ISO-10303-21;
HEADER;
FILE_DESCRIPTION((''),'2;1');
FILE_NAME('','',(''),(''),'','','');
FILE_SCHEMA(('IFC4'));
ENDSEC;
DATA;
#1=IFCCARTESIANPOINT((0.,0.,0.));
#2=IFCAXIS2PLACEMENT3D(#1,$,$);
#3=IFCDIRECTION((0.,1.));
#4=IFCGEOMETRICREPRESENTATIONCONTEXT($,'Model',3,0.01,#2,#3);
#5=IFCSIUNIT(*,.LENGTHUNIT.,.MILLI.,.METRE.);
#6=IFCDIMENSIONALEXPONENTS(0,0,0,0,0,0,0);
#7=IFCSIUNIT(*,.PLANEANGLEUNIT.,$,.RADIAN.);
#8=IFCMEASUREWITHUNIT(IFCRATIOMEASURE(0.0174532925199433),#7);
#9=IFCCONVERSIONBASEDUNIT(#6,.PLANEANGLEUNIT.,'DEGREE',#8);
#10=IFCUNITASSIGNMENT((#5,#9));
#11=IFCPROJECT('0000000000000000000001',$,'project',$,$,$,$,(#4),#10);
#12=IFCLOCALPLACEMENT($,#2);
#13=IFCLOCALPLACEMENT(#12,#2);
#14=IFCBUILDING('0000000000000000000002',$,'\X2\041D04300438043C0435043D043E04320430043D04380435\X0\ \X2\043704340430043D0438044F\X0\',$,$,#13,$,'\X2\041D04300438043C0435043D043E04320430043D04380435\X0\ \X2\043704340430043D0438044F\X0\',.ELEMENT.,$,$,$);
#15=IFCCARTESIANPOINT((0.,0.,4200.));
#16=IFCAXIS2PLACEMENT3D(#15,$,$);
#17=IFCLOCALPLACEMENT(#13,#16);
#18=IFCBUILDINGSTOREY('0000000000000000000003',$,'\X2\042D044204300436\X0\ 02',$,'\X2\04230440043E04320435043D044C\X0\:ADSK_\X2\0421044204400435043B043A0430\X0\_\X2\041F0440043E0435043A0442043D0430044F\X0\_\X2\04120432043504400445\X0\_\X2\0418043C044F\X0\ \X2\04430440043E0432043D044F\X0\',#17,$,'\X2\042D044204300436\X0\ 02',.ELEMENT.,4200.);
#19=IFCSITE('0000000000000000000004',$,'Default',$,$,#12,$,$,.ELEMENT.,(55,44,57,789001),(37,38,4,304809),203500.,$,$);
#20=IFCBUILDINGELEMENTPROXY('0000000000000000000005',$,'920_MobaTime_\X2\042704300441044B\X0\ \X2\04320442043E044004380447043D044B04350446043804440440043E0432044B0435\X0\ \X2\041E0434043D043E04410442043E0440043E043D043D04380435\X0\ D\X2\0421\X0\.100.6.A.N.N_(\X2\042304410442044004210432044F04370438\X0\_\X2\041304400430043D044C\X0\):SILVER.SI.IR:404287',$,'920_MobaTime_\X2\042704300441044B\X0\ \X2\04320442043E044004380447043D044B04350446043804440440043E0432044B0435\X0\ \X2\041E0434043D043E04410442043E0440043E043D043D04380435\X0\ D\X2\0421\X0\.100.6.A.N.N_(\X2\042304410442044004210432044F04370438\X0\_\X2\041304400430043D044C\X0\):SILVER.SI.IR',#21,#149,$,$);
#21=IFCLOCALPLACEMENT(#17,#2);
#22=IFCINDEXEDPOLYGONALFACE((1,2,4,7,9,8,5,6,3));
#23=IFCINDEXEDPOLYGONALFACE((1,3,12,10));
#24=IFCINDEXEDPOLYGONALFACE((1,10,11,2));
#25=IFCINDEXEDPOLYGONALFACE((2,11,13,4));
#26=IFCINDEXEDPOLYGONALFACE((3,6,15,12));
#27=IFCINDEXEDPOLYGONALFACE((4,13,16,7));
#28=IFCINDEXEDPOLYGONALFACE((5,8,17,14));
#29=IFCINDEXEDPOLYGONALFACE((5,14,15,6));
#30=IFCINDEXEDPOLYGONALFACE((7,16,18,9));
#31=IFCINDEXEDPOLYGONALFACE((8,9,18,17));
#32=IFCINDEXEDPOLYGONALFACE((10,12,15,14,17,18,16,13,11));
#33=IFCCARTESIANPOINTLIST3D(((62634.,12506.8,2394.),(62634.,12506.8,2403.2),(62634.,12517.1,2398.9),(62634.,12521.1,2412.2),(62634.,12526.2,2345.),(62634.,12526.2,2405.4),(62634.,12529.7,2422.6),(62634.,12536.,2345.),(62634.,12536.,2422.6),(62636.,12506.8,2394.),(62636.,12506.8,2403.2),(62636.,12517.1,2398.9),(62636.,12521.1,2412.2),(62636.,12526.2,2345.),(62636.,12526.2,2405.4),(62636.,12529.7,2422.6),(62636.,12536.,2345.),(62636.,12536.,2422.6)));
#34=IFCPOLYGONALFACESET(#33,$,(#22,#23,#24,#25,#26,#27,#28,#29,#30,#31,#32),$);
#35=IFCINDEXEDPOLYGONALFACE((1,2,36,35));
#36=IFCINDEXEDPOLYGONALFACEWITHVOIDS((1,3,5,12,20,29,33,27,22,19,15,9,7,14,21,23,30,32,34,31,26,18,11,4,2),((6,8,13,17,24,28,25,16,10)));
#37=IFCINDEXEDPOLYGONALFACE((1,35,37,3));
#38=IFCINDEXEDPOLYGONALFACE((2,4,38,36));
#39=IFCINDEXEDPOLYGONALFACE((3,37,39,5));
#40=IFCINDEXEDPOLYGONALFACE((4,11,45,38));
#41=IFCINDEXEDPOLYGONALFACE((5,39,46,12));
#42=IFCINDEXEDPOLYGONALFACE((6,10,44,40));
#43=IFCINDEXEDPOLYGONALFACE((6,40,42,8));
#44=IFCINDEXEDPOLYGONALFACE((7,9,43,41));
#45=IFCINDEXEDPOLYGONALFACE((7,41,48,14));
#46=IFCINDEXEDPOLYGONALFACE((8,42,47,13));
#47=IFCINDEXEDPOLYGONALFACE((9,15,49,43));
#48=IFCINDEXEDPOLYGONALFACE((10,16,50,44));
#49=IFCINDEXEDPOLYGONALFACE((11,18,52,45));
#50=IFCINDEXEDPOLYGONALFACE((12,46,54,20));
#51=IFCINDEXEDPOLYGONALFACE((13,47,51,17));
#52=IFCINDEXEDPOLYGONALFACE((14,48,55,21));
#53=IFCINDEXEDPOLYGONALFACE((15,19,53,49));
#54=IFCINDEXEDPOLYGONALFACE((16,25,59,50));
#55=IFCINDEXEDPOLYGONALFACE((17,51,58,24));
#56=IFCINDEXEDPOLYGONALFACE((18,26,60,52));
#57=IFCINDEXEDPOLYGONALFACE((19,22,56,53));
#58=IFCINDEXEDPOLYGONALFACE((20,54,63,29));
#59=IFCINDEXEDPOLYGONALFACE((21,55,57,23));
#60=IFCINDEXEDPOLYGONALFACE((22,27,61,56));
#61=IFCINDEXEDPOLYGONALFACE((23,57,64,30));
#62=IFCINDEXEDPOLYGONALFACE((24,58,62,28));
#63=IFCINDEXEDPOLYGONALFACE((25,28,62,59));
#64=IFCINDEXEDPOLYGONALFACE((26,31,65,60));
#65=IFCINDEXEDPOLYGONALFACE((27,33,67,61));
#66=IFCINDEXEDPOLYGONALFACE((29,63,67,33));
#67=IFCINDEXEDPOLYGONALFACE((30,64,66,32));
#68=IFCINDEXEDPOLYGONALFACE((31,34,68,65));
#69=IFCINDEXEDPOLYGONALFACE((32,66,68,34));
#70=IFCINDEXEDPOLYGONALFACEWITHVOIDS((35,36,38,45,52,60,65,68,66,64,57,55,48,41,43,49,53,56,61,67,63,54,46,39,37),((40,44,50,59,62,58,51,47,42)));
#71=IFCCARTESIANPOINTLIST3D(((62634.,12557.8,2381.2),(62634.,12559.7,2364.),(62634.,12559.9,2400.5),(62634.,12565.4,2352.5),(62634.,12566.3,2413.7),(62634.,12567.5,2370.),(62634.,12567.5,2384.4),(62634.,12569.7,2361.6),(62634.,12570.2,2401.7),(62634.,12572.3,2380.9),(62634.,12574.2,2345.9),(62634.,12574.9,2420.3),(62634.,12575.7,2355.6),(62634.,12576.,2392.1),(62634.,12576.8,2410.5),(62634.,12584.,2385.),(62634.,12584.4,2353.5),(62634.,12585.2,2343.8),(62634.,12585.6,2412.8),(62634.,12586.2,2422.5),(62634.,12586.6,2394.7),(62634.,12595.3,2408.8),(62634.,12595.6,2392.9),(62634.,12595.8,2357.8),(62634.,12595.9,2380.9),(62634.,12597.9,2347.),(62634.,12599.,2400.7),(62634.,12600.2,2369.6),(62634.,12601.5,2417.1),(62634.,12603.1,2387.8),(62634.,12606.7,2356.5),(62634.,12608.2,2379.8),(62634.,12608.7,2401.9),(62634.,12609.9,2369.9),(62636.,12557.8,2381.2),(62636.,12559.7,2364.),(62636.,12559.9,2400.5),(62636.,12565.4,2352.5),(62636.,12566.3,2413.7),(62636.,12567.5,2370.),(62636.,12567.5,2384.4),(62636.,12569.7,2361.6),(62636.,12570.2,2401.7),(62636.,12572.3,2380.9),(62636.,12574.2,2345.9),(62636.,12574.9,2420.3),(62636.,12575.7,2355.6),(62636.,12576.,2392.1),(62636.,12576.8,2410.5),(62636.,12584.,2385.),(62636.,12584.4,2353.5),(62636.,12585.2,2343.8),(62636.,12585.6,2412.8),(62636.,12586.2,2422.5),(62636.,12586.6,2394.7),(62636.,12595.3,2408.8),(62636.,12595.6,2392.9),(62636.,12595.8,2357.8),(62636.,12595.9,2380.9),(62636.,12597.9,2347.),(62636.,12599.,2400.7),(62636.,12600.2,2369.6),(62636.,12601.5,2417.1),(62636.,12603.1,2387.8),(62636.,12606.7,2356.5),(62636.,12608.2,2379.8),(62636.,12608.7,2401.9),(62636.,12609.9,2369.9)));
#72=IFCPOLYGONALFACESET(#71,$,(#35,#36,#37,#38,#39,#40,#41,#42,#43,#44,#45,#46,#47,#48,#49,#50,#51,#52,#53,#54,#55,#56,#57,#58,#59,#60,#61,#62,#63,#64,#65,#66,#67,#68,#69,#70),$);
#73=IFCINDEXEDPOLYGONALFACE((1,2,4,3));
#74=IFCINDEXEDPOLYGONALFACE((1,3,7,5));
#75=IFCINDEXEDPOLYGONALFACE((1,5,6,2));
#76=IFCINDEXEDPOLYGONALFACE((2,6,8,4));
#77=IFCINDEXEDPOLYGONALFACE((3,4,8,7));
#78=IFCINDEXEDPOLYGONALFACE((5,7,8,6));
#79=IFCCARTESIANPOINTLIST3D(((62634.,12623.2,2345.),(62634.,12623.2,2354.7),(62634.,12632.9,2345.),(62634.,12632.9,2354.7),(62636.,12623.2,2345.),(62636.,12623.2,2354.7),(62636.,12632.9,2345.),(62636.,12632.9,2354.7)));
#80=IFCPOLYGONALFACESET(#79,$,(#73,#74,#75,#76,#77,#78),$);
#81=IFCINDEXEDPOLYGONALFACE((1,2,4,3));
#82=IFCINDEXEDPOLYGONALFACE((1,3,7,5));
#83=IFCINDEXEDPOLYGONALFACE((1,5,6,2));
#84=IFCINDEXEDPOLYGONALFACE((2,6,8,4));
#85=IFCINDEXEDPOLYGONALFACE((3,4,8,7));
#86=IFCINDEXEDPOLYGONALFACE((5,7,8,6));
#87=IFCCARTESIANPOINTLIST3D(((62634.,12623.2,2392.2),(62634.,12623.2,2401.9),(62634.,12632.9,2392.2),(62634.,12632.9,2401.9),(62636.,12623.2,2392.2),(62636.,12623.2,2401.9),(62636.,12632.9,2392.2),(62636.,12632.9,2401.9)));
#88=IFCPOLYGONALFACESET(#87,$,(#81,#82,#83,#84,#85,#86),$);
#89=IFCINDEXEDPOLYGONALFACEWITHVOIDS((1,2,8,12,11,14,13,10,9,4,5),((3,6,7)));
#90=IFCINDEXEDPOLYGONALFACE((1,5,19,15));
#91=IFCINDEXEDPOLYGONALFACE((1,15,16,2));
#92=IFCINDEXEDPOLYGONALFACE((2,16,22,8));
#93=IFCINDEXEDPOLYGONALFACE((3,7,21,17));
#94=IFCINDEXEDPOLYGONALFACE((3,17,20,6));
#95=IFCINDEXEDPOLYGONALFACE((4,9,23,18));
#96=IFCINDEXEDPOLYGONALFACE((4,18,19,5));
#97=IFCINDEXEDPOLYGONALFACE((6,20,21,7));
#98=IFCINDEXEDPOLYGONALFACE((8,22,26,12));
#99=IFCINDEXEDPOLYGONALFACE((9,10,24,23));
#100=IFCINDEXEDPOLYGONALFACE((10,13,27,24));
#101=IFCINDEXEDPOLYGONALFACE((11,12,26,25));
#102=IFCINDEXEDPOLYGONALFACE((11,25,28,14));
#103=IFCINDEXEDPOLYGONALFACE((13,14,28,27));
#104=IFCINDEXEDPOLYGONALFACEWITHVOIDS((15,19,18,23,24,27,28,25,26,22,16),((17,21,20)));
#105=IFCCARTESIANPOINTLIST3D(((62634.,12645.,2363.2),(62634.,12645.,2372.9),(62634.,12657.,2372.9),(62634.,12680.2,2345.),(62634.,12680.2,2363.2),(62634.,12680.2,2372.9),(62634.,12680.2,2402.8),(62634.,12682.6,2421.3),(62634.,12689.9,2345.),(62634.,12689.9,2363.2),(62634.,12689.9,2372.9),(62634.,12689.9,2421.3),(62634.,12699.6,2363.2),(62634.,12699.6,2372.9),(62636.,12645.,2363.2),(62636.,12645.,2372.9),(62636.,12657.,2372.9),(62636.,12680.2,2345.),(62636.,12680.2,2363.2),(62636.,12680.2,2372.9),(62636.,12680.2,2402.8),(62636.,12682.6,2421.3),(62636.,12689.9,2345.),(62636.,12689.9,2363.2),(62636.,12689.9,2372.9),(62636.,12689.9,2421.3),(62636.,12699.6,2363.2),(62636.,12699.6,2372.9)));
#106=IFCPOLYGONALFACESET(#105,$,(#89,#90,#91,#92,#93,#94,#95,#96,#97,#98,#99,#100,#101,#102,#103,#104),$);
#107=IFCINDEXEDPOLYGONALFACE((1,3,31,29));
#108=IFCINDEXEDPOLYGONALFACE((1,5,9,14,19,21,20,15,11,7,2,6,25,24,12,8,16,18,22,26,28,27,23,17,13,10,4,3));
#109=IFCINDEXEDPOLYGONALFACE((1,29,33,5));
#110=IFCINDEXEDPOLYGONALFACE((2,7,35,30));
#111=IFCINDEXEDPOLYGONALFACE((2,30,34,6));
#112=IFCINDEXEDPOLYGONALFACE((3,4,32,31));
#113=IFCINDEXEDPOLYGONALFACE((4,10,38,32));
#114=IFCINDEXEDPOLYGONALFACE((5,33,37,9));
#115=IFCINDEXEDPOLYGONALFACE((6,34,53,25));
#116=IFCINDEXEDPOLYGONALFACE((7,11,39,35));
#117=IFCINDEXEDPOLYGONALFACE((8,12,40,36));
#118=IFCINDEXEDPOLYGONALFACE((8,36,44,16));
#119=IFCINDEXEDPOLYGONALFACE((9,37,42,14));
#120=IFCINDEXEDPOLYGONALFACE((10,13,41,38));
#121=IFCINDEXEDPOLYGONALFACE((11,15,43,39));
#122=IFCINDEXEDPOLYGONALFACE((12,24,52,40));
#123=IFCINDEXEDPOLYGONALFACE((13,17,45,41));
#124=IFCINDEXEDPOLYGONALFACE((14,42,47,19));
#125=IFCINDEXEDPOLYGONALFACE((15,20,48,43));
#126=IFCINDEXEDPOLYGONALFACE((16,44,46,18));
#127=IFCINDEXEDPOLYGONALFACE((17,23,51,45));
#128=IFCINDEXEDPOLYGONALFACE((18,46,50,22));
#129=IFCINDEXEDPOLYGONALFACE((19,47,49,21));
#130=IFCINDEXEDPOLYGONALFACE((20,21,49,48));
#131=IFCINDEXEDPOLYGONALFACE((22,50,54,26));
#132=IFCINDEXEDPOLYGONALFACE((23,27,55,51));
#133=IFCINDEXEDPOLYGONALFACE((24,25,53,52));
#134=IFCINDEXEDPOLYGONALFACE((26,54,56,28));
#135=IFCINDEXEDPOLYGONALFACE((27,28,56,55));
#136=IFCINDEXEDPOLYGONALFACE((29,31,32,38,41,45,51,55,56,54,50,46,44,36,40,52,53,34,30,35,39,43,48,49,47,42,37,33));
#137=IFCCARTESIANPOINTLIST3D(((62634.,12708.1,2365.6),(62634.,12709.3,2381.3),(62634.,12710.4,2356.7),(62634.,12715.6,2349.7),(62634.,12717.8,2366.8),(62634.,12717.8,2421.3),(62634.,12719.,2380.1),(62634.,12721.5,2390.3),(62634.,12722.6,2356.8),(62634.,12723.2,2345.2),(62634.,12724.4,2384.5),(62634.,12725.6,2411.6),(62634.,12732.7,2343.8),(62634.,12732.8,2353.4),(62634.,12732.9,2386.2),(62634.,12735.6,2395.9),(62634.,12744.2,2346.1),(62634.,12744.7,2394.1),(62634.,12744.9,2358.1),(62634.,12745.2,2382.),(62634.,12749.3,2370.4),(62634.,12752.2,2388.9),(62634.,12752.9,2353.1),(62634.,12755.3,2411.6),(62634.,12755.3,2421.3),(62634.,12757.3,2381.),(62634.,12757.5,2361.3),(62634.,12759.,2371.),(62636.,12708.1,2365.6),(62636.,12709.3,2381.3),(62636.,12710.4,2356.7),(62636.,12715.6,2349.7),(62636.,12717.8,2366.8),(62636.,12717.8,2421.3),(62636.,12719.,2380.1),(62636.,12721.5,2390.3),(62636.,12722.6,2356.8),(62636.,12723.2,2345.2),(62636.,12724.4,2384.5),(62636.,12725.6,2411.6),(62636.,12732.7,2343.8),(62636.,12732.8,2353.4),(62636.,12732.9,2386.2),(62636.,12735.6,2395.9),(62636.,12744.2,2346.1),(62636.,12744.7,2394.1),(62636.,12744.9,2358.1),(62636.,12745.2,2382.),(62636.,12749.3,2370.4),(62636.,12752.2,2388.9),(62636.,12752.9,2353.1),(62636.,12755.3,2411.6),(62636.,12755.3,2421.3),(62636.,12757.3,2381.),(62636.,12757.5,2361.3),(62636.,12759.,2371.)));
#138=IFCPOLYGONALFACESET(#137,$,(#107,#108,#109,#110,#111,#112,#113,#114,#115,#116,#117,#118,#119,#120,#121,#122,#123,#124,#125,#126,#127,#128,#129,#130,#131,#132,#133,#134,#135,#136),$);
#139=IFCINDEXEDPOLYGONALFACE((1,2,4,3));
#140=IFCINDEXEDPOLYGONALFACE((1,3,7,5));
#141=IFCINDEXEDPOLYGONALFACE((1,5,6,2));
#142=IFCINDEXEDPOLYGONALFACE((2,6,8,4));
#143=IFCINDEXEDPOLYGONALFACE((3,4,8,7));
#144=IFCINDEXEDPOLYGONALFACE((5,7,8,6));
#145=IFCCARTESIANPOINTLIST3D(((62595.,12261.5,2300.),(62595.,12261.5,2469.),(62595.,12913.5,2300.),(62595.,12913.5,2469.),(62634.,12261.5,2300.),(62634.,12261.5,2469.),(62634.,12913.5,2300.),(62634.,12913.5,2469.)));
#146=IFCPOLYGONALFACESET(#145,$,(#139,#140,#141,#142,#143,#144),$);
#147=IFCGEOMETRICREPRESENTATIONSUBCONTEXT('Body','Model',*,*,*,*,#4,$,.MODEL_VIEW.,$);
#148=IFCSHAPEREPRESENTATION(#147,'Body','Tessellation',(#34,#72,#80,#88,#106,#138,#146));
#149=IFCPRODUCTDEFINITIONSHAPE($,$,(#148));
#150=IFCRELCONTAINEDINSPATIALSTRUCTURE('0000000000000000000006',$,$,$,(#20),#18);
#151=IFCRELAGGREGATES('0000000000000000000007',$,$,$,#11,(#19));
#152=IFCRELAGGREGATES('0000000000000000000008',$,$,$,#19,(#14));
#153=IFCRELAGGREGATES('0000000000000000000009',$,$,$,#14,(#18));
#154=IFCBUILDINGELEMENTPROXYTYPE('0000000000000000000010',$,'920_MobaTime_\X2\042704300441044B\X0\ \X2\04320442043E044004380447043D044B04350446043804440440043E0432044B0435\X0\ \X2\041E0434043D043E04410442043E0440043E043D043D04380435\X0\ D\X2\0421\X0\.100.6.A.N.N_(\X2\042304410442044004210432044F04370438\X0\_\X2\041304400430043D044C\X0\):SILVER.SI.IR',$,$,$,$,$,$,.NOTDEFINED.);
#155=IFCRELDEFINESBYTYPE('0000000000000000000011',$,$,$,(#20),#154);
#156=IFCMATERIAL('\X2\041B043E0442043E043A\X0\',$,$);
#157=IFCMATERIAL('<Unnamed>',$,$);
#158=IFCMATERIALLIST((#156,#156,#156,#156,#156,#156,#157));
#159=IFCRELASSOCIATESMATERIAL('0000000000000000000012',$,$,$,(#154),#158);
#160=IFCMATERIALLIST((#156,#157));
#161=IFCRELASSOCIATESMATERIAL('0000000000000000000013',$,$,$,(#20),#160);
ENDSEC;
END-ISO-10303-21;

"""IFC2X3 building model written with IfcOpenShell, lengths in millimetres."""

from ifc_helpers import new_model, entity, si_unit, converted_unit, direction, frame, origin, origin_2d_with_axis, place, context, subcontext, project, spatial, polyline, rectangle, outline, extrude, source, transform, mapped, material, material_list, type_object, type_shapes, element, save


model = new_model("IFC2X3")

# Units and contexts
model_context = context("Model", 3, precision=0.01, world=origin(), true_north=direction((0.0, 1.0)))
body_context = subcontext(model_context, "Body", "Model", "MODEL_VIEW")
ifc_project = project(units=[si_unit("LENGTHUNIT", "METRE", prefix="MILLI"), converted_unit("PLANEANGLEUNIT", "DEGREE", entity("IfcRatioMeasure", 0.0174532925199433), si_unit("PLANEANGLEUNIT", "RADIAN"), dimensions=[0, 0, 0, 0, 0, 0, 0])], contexts=[model_context])

# Site, building, storey
site_placement = place(None, origin())
site = spatial("IfcSite", under=ifc_project, at=site_placement, Name="Default", CompositionType="ELEMENT", RefLatitude=(55, 44, 57, 789001), RefLongitude=(37, 38, 4, 304809), RefElevation=203500.0)
building_placement = place(site_placement, origin())
building = spatial("IfcBuilding", under=site, at=building_placement, Name="Наименование здания", LongName="Наименование здания", CompositionType="ELEMENT")
storey_placement = place(building_placement, frame((0.0, 0.0, 4200.0)))
storey = spatial("IfcBuildingStorey", under=building, at=storey_placement, Name="Этаж 02", ObjectType="Уровень:ADSK_Стрелка_Проектная_Вверх_Имя уровня", LongName="Этаж 02", CompositionType="ELEMENT", Elevation=4200.0)

# Building element proxy
ifc_material_1 = material(Name="Лоток")
ifc_material_2 = material(Name="<Unnamed>")
ifc_material_list_1 = material_list([ifc_material_1, ifc_material_2])
ifc_material_list_2 = material_list([ifc_material_1, ifc_material_1, ifc_material_1, ifc_material_1, ifc_material_1, ifc_material_1, ifc_material_2])
building_element_proxy_type_1 = type_object("IfcBuildingElementProxyType", Name="920_MobaTime_Часы вторичныецифровые Односторонние DС.100.6.A.N.N_(УстрСвязи_Грань):SILVER.SI.IR", PredefinedType="NOTDEFINED", material=ifc_material_list_2)
shared_shape_1 = source(origin(), body_context, "Body", "SweptSolid", [
    extrude(outline(polyline([(-49.3, -13.1), (28.2, -13.1), (28.2, -6.8), (17.9, 1.8), (8.8, 16.0), (-0.3, 16.0), (4.6, 5.8), (11.1, -3.4), (-49.3, -3.4), (-49.3, -13.1)])), frame((-64.6, 9.8, 39.0), z_axis=(0.0, 0.0, 1.0), x_axis=(0.0, 1.0, 0.0)), (0.0, 0.0, 1.0), 2.0),
    extrude(outline(polyline([(2.2, -27.6), (19.0, -27.6), (30.5, -16.1), (33.3, -4.9), (31.0, 5.8), (21.8, 17.2), (5.2, 27.3), (-11.1, 33.0), (-24.0, 32.7), (-33.6, 27.6), (-40.3, 18.6), (-42.8, 5.7), (-38.0, -6.3), (-27.2, -14.9), (-17.5, -17.7), (-8.2, -16.4), (-0.3, -11.9), (5.1, -4.5), (7.3, 6.2), (4.0, 17.2), (18.4, 7.3), (23.6, -2.4), (22.0, -11.4), (14.2, -18.4), (5.3, -18.3), (2.2, -27.6)]), holes=[polyline([(-9.0, 23.3), (-1.3, 14.3), (-2.5, 2.0), (-11.4, -7.0), (-23.4, -6.0), (-32.2, 2.9), (-31.2, 15.1), (-25.6, 22.1), (-17.5, 24.9), (-9.0, 23.3)])]), frame((-2.7, 3.6, 39.0), z_axis=(0.0, 0.0, 1.0), x_axis=(-0.427649, 0.903945, 0.0)), (0.0, 0.0, 1.0), 2.0),
    extrude(rectangle(XDim=9.7, YDim=9.7, at=origin_2d_with_axis()), frame((40.6, -34.7, 39.0)), (0.0, 0.0, 1.0), 2.0),
    extrude(rectangle(XDim=9.7, YDim=9.7, at=origin_2d_with_axis()), frame((40.6, 12.6, 39.0)), (0.0, 0.0, 1.0), 2.0),
    extrude(outline(polyline([(-0.9, -28.1), (8.8, -28.1), (8.8, -9.9), (18.5, -9.9), (18.5, -0.2), (8.8, -0.2), (8.8, 48.3), (1.5, 48.3), (-36.0, -0.2), (-36.0, -9.9), (-0.9, -9.9), (-0.9, -28.1)]), holes=[polyline([(-0.9, -0.2), (-24.1, -0.2), (-0.9, 29.7), (-0.9, -0.2)])]), frame((93.6, -11.4, 39.0)), (0.0, 0.0, 1.0), 2.0),
    extrude(outline(polyline([(3.3, -28.3), (12.5, -28.3), (20.5, -25.0), (26.8, -18.9), (30.7, -10.0), (31.4, 1.6), (26.9, 11.8), (20.1, 18.4), (11.1, 22.3), (1.0, 23.3), (-7.9, 20.4), (-14.9, 14.5), (-18.9, 6.2), (-17.1, -9.0), (-36.7, 0.5), (-29.1, 29.2), (-38.5, 31.7), (-48.1, -4.6), (-11.6, -23.1), (-8.0, -14.0), (-10.8, -7.6), (-10.2, 1.1), (-3.0, 11.8), (9.2, 12.8), (20.0, 5.5), (21.4, -7.5), (15.5, -16.4), (4.6, -18.6), (3.3, -28.3)])), frame((147.1, -8.5, 39.0), z_axis=(0.0, 0.0, 1.0), x_axis=(0.256974, -0.966418, 0.0)), (0.0, 0.0, 1.0), 2.0),
    extrude(rectangle(XDim=652.0, YDim=169.0, at=origin_2d_with_axis()), frame((0.0, 0.0, 0.0), z_axis=(0.0, 0.0, 1.0), x_axis=(-1.0, 0.0, 0.0)), (0.0, 0.0, 1.0), 39.0),
])
type_shapes(building_element_proxy_type_1, [shared_shape_1])
for number, where, z_axis, x_axis, name in (
    (1, (62595.0, 12587.5, 2384.5), (1.0, 0.0, 0.0), (0.0, 1.0, 0.0), "920_MobaTime_Часы вторичныецифровые Односторонние DС.100.6.A.N.N_(УстрСвязи_Грань):SILVER.SI.IR:404287"),
):
    element("IfcBuildingElementProxy", number, at=place(storey_placement, frame(where, z_axis=z_axis, x_axis=x_axis)), inside=storey, type_object=building_element_proxy_type_1, material=ifc_material_list_1, Name=name, ObjectType="920_MobaTime_Часы вторичныецифровые Односторонние DС.100.6.A.N.N_(УстрСвязи_Грань):SILVER.SI.IR", context=body_context, shape_type="MappedRepresentation", body=[
        mapped(shared_shape_1, transform((0.0, 0.0, 0.0), scale=1.0)),
    ])

save(model, "model.ifc")
